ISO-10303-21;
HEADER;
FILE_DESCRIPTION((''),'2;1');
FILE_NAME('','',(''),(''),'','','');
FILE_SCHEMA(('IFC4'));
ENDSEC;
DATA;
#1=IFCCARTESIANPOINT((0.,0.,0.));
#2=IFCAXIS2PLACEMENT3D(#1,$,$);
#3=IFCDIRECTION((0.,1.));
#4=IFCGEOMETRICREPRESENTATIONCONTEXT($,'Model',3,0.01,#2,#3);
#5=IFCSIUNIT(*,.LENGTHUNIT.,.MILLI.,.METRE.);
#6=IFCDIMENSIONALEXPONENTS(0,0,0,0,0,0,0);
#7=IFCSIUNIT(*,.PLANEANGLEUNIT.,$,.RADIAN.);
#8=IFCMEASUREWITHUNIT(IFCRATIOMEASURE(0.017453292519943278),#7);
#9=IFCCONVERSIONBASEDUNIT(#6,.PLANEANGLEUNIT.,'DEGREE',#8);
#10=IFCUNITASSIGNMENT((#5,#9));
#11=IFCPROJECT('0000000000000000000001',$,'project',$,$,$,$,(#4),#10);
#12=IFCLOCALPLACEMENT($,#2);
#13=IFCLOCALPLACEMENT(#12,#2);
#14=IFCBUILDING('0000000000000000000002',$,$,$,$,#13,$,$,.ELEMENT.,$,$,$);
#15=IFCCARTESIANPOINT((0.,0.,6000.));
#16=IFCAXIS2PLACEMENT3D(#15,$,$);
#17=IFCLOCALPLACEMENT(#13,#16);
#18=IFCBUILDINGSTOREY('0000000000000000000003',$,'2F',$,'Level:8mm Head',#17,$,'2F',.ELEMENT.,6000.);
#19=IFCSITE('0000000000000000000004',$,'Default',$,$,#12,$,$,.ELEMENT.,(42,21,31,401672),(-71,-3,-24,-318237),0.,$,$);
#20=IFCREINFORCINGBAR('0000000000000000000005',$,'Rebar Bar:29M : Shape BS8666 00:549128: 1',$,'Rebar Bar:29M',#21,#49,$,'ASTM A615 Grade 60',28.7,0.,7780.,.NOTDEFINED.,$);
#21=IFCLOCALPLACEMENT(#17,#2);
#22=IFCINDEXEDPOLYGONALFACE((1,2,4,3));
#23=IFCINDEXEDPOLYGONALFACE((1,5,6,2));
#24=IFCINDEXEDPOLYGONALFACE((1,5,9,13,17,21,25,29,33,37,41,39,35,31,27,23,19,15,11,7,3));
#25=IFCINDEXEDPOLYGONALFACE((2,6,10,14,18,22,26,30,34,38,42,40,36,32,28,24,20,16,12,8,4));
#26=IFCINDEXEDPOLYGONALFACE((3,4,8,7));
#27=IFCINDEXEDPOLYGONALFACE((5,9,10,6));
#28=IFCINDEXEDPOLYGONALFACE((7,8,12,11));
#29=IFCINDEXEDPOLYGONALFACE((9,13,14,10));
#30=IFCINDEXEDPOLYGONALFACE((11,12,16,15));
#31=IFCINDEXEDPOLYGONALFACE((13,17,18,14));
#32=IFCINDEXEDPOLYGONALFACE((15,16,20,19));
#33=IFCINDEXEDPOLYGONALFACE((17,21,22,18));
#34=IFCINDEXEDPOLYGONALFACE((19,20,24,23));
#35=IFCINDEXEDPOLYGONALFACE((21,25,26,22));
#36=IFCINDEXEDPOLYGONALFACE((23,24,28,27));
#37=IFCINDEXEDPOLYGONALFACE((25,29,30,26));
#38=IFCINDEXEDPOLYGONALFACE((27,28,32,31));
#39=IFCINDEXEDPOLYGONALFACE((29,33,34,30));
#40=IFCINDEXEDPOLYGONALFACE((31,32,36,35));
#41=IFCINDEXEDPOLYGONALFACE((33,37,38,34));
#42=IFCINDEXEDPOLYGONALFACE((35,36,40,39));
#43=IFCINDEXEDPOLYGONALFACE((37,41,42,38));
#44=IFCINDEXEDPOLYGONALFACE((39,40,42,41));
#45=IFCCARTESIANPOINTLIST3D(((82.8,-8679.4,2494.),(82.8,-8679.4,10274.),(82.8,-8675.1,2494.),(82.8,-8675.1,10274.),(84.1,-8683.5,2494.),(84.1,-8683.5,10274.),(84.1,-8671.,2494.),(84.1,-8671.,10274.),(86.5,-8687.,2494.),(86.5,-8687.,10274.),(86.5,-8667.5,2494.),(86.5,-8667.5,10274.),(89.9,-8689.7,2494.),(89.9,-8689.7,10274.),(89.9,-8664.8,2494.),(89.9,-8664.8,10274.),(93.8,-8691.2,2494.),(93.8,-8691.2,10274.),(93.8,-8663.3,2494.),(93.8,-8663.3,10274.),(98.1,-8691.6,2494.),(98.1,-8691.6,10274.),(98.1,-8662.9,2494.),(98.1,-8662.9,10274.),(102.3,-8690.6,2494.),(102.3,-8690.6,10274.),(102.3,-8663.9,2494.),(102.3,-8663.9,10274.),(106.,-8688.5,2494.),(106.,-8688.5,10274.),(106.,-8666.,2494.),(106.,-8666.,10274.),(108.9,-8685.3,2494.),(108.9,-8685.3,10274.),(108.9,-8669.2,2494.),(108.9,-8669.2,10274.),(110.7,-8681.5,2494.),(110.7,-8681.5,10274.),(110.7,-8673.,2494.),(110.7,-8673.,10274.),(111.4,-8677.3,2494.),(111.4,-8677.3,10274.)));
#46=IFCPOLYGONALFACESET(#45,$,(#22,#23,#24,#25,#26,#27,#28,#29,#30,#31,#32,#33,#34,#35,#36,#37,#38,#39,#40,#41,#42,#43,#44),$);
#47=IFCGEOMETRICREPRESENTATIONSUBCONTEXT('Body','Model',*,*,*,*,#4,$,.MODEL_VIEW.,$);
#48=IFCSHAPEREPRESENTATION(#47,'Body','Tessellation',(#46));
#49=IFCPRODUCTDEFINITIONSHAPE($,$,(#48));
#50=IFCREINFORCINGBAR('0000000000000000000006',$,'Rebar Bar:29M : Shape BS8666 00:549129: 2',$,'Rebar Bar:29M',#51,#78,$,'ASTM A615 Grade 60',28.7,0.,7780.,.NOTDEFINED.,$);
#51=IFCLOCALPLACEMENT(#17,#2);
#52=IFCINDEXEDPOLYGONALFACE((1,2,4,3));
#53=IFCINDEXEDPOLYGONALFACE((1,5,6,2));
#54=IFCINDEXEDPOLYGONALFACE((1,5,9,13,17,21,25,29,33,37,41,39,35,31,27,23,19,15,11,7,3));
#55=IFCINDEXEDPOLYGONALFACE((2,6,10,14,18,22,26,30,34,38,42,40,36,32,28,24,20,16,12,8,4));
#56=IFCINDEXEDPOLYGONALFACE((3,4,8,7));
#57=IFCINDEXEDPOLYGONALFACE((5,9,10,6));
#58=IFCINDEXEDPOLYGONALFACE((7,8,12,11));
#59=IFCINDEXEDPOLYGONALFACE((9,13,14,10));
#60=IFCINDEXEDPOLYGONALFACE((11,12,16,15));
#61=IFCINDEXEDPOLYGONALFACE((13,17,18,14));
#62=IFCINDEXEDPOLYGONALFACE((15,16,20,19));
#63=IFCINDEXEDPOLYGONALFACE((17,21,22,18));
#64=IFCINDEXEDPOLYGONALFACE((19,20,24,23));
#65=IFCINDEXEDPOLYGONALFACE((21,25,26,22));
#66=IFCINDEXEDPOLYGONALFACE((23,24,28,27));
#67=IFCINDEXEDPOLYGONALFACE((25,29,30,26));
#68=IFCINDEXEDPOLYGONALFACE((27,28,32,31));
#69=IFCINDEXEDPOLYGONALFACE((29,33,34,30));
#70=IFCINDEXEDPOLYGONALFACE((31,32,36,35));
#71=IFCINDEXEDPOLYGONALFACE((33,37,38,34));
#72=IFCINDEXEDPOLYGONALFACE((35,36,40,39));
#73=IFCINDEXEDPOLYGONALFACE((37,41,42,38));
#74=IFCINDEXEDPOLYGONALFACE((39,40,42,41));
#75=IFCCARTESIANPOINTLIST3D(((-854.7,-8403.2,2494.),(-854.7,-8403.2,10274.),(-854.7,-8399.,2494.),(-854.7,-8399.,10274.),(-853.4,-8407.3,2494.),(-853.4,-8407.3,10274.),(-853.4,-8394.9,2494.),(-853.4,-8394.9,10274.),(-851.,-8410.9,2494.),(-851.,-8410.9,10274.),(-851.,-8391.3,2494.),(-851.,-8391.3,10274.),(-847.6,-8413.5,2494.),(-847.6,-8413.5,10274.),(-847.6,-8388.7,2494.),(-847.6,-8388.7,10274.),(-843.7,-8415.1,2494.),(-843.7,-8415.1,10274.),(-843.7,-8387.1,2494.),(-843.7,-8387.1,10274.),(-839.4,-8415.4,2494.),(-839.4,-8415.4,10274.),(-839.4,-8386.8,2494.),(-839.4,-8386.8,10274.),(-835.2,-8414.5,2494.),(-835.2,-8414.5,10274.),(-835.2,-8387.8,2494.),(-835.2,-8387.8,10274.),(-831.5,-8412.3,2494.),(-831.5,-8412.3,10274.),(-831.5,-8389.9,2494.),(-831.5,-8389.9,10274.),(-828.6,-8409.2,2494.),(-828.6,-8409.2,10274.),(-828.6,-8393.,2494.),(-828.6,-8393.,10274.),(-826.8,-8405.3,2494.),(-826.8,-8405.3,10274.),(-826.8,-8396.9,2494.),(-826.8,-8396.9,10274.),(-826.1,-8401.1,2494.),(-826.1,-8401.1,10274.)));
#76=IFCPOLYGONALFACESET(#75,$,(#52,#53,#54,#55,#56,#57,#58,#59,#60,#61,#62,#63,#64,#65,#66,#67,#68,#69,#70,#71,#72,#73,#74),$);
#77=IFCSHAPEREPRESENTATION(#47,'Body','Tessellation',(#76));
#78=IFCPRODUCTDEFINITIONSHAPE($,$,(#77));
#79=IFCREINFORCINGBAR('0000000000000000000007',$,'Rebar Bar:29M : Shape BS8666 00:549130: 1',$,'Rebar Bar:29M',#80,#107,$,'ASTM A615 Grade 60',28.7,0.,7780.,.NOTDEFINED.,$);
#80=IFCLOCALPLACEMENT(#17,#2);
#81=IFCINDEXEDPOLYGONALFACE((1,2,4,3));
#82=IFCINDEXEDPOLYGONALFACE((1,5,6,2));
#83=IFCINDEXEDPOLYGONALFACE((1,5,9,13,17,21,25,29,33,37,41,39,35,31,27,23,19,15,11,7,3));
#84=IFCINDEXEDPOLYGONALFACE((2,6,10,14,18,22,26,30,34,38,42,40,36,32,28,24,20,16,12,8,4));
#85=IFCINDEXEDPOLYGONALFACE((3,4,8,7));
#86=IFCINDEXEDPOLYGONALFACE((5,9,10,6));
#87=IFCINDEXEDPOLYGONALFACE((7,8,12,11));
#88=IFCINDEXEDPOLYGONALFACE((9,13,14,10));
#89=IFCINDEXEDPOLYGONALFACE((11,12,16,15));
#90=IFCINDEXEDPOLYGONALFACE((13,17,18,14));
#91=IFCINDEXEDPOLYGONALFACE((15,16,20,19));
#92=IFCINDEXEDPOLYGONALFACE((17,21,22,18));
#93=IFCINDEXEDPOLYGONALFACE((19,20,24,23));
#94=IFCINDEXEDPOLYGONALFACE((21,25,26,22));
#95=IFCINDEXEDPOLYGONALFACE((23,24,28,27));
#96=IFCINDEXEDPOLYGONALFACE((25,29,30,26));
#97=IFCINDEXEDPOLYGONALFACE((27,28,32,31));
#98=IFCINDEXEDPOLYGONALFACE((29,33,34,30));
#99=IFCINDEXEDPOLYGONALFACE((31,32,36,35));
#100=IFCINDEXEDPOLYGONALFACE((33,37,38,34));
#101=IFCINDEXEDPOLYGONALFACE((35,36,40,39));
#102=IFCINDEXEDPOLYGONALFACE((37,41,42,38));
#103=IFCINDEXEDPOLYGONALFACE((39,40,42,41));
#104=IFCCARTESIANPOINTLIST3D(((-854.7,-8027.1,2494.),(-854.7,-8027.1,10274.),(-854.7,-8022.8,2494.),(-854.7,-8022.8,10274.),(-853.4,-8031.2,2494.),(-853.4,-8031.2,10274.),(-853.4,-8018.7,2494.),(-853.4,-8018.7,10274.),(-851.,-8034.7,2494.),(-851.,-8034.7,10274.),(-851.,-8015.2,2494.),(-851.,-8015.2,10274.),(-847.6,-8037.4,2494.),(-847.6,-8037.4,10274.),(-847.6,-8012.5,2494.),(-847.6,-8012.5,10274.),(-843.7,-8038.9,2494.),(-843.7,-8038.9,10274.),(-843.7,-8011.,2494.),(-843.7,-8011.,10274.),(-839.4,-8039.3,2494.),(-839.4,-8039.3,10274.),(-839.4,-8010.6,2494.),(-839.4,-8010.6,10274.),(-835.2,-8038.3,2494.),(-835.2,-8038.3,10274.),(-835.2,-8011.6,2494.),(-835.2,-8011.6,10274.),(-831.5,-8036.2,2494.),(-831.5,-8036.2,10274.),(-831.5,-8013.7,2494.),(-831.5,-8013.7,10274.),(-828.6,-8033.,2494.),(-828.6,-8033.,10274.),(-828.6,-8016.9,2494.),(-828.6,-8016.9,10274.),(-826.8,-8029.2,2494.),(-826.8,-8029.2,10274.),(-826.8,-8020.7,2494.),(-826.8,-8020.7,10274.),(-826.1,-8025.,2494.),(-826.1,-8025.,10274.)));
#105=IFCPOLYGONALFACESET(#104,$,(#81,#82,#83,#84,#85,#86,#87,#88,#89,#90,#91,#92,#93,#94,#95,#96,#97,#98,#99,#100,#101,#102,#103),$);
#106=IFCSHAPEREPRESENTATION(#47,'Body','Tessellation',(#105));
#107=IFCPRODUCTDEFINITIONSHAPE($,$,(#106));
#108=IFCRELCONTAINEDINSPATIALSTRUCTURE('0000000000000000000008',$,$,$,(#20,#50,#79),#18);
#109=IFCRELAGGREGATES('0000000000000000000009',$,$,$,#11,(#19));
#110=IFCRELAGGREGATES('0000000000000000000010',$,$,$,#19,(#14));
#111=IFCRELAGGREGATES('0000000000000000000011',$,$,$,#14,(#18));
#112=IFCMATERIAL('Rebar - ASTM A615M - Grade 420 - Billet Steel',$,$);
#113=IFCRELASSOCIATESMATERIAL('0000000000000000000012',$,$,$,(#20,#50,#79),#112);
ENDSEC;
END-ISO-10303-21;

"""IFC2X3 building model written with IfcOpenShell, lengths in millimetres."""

from ifc_helpers import new_model, entity, si_unit, converted_unit, direction, frame, origin, place, context, subcontext, project, spatial, material, element, save


model = new_model("IFC2X3")

# Units and contexts
model_context = context("Model", 3, precision=0.01, world=origin(), true_north=direction((0.0, 1.0)))
body_context = subcontext(model_context, "Body", "Model", "MODEL_VIEW")
ifc_project = project(units=[si_unit("LENGTHUNIT", "METRE", prefix="MILLI"), converted_unit("PLANEANGLEUNIT", "DEGREE", entity("IfcRatioMeasure", 0.017453292519943278), si_unit("PLANEANGLEUNIT", "RADIAN"), dimensions=[0, 0, 0, 0, 0, 0, 0])], contexts=[model_context])

# Site, building, storey
site_placement = place(None, origin())
site = spatial("IfcSite", under=ifc_project, at=site_placement, Name="Default", CompositionType="ELEMENT", RefLatitude=(42, 21, 31, 401672), RefLongitude=(-71, -3, -24, -318237), RefElevation=0.0)
building_placement = place(site_placement, origin())
building = spatial("IfcBuilding", under=site, at=building_placement, CompositionType="ELEMENT")
storey_placement = place(building_placement, frame((0.0, 0.0, 6000.0)))
storey = spatial("IfcBuildingStorey", under=building, at=storey_placement, Name="2F", ObjectType="Level:8mm Head", LongName="2F", CompositionType="ELEMENT", Elevation=6000.0)

# Reinforcing bars
ifc_material = material(Name="Rebar - ASTM A615M - Grade 420 - Billet Steel")
reinforcing_bar_1_placement = place(storey_placement, origin())
element("IfcReinforcingBar", 1, at=reinforcing_bar_1_placement, inside=storey, material=ifc_material, Name="Rebar Bar:29M : Shape BS8666 00:549128: 1", SteelGrade="ASTM A615 Grade 60", ObjectType="Rebar Bar:29M", BarLength=7780.0, BarRole="NOTDEFINED", CrossSectionArea=0.0, NominalDiameter=28.7, context=body_context, shape_type="AdvancedSweptSolid", body=[
    entity("IfcSweptDiskSolid", entity("IfcCompositeCurve", [entity("IfcCompositeCurveSegment", "CONTINUOUS", True, entity("IfcPolyline", [entity("IfcCartesianPoint", [97.0, -8677.3, 2494.0]), entity("IfcCartesianPoint", [97.0, -8677.3, 10274.0])]))], False), 14.3, None, 0.0, 1.0),
])
reinforcing_bar_2_placement = place(storey_placement, origin())
element("IfcReinforcingBar", 2, at=reinforcing_bar_2_placement, inside=storey, material=ifc_material, Name="Rebar Bar:29M : Shape BS8666 00:549129: 2", SteelGrade="ASTM A615 Grade 60", ObjectType="Rebar Bar:29M", BarLength=7780.0, BarRole="NOTDEFINED", CrossSectionArea=0.0, NominalDiameter=28.7, context=body_context, shape_type="AdvancedSweptSolid", body=[
    entity("IfcSweptDiskSolid", entity("IfcCompositeCurve", [entity("IfcCompositeCurveSegment", "CONTINUOUS", True, entity("IfcPolyline", [entity("IfcCartesianPoint", [-840.5, -8401.1, 2494.0]), entity("IfcCartesianPoint", [-840.5, -8401.1, 10274.0])]))], False), 14.3, None, 0.0, 1.0),
])
reinforcing_bar_3_placement = place(storey_placement, origin())
element("IfcReinforcingBar", 3, at=reinforcing_bar_3_placement, inside=storey, material=ifc_material, Name="Rebar Bar:29M : Shape BS8666 00:549130: 1", SteelGrade="ASTM A615 Grade 60", ObjectType="Rebar Bar:29M", BarLength=7780.0, BarRole="NOTDEFINED", CrossSectionArea=0.0, NominalDiameter=28.7, context=body_context, shape_type="AdvancedSweptSolid", body=[
    entity("IfcSweptDiskSolid", entity("IfcCompositeCurve", [entity("IfcCompositeCurveSegment", "CONTINUOUS", True, entity("IfcPolyline", [entity("IfcCartesianPoint", [-840.5, -8025.0, 2494.0]), entity("IfcCartesianPoint", [-840.5, -8025.0, 10274.0])]))], False), 14.3, None, 0.0, 1.0),
])

save(model, "model.ifc")
